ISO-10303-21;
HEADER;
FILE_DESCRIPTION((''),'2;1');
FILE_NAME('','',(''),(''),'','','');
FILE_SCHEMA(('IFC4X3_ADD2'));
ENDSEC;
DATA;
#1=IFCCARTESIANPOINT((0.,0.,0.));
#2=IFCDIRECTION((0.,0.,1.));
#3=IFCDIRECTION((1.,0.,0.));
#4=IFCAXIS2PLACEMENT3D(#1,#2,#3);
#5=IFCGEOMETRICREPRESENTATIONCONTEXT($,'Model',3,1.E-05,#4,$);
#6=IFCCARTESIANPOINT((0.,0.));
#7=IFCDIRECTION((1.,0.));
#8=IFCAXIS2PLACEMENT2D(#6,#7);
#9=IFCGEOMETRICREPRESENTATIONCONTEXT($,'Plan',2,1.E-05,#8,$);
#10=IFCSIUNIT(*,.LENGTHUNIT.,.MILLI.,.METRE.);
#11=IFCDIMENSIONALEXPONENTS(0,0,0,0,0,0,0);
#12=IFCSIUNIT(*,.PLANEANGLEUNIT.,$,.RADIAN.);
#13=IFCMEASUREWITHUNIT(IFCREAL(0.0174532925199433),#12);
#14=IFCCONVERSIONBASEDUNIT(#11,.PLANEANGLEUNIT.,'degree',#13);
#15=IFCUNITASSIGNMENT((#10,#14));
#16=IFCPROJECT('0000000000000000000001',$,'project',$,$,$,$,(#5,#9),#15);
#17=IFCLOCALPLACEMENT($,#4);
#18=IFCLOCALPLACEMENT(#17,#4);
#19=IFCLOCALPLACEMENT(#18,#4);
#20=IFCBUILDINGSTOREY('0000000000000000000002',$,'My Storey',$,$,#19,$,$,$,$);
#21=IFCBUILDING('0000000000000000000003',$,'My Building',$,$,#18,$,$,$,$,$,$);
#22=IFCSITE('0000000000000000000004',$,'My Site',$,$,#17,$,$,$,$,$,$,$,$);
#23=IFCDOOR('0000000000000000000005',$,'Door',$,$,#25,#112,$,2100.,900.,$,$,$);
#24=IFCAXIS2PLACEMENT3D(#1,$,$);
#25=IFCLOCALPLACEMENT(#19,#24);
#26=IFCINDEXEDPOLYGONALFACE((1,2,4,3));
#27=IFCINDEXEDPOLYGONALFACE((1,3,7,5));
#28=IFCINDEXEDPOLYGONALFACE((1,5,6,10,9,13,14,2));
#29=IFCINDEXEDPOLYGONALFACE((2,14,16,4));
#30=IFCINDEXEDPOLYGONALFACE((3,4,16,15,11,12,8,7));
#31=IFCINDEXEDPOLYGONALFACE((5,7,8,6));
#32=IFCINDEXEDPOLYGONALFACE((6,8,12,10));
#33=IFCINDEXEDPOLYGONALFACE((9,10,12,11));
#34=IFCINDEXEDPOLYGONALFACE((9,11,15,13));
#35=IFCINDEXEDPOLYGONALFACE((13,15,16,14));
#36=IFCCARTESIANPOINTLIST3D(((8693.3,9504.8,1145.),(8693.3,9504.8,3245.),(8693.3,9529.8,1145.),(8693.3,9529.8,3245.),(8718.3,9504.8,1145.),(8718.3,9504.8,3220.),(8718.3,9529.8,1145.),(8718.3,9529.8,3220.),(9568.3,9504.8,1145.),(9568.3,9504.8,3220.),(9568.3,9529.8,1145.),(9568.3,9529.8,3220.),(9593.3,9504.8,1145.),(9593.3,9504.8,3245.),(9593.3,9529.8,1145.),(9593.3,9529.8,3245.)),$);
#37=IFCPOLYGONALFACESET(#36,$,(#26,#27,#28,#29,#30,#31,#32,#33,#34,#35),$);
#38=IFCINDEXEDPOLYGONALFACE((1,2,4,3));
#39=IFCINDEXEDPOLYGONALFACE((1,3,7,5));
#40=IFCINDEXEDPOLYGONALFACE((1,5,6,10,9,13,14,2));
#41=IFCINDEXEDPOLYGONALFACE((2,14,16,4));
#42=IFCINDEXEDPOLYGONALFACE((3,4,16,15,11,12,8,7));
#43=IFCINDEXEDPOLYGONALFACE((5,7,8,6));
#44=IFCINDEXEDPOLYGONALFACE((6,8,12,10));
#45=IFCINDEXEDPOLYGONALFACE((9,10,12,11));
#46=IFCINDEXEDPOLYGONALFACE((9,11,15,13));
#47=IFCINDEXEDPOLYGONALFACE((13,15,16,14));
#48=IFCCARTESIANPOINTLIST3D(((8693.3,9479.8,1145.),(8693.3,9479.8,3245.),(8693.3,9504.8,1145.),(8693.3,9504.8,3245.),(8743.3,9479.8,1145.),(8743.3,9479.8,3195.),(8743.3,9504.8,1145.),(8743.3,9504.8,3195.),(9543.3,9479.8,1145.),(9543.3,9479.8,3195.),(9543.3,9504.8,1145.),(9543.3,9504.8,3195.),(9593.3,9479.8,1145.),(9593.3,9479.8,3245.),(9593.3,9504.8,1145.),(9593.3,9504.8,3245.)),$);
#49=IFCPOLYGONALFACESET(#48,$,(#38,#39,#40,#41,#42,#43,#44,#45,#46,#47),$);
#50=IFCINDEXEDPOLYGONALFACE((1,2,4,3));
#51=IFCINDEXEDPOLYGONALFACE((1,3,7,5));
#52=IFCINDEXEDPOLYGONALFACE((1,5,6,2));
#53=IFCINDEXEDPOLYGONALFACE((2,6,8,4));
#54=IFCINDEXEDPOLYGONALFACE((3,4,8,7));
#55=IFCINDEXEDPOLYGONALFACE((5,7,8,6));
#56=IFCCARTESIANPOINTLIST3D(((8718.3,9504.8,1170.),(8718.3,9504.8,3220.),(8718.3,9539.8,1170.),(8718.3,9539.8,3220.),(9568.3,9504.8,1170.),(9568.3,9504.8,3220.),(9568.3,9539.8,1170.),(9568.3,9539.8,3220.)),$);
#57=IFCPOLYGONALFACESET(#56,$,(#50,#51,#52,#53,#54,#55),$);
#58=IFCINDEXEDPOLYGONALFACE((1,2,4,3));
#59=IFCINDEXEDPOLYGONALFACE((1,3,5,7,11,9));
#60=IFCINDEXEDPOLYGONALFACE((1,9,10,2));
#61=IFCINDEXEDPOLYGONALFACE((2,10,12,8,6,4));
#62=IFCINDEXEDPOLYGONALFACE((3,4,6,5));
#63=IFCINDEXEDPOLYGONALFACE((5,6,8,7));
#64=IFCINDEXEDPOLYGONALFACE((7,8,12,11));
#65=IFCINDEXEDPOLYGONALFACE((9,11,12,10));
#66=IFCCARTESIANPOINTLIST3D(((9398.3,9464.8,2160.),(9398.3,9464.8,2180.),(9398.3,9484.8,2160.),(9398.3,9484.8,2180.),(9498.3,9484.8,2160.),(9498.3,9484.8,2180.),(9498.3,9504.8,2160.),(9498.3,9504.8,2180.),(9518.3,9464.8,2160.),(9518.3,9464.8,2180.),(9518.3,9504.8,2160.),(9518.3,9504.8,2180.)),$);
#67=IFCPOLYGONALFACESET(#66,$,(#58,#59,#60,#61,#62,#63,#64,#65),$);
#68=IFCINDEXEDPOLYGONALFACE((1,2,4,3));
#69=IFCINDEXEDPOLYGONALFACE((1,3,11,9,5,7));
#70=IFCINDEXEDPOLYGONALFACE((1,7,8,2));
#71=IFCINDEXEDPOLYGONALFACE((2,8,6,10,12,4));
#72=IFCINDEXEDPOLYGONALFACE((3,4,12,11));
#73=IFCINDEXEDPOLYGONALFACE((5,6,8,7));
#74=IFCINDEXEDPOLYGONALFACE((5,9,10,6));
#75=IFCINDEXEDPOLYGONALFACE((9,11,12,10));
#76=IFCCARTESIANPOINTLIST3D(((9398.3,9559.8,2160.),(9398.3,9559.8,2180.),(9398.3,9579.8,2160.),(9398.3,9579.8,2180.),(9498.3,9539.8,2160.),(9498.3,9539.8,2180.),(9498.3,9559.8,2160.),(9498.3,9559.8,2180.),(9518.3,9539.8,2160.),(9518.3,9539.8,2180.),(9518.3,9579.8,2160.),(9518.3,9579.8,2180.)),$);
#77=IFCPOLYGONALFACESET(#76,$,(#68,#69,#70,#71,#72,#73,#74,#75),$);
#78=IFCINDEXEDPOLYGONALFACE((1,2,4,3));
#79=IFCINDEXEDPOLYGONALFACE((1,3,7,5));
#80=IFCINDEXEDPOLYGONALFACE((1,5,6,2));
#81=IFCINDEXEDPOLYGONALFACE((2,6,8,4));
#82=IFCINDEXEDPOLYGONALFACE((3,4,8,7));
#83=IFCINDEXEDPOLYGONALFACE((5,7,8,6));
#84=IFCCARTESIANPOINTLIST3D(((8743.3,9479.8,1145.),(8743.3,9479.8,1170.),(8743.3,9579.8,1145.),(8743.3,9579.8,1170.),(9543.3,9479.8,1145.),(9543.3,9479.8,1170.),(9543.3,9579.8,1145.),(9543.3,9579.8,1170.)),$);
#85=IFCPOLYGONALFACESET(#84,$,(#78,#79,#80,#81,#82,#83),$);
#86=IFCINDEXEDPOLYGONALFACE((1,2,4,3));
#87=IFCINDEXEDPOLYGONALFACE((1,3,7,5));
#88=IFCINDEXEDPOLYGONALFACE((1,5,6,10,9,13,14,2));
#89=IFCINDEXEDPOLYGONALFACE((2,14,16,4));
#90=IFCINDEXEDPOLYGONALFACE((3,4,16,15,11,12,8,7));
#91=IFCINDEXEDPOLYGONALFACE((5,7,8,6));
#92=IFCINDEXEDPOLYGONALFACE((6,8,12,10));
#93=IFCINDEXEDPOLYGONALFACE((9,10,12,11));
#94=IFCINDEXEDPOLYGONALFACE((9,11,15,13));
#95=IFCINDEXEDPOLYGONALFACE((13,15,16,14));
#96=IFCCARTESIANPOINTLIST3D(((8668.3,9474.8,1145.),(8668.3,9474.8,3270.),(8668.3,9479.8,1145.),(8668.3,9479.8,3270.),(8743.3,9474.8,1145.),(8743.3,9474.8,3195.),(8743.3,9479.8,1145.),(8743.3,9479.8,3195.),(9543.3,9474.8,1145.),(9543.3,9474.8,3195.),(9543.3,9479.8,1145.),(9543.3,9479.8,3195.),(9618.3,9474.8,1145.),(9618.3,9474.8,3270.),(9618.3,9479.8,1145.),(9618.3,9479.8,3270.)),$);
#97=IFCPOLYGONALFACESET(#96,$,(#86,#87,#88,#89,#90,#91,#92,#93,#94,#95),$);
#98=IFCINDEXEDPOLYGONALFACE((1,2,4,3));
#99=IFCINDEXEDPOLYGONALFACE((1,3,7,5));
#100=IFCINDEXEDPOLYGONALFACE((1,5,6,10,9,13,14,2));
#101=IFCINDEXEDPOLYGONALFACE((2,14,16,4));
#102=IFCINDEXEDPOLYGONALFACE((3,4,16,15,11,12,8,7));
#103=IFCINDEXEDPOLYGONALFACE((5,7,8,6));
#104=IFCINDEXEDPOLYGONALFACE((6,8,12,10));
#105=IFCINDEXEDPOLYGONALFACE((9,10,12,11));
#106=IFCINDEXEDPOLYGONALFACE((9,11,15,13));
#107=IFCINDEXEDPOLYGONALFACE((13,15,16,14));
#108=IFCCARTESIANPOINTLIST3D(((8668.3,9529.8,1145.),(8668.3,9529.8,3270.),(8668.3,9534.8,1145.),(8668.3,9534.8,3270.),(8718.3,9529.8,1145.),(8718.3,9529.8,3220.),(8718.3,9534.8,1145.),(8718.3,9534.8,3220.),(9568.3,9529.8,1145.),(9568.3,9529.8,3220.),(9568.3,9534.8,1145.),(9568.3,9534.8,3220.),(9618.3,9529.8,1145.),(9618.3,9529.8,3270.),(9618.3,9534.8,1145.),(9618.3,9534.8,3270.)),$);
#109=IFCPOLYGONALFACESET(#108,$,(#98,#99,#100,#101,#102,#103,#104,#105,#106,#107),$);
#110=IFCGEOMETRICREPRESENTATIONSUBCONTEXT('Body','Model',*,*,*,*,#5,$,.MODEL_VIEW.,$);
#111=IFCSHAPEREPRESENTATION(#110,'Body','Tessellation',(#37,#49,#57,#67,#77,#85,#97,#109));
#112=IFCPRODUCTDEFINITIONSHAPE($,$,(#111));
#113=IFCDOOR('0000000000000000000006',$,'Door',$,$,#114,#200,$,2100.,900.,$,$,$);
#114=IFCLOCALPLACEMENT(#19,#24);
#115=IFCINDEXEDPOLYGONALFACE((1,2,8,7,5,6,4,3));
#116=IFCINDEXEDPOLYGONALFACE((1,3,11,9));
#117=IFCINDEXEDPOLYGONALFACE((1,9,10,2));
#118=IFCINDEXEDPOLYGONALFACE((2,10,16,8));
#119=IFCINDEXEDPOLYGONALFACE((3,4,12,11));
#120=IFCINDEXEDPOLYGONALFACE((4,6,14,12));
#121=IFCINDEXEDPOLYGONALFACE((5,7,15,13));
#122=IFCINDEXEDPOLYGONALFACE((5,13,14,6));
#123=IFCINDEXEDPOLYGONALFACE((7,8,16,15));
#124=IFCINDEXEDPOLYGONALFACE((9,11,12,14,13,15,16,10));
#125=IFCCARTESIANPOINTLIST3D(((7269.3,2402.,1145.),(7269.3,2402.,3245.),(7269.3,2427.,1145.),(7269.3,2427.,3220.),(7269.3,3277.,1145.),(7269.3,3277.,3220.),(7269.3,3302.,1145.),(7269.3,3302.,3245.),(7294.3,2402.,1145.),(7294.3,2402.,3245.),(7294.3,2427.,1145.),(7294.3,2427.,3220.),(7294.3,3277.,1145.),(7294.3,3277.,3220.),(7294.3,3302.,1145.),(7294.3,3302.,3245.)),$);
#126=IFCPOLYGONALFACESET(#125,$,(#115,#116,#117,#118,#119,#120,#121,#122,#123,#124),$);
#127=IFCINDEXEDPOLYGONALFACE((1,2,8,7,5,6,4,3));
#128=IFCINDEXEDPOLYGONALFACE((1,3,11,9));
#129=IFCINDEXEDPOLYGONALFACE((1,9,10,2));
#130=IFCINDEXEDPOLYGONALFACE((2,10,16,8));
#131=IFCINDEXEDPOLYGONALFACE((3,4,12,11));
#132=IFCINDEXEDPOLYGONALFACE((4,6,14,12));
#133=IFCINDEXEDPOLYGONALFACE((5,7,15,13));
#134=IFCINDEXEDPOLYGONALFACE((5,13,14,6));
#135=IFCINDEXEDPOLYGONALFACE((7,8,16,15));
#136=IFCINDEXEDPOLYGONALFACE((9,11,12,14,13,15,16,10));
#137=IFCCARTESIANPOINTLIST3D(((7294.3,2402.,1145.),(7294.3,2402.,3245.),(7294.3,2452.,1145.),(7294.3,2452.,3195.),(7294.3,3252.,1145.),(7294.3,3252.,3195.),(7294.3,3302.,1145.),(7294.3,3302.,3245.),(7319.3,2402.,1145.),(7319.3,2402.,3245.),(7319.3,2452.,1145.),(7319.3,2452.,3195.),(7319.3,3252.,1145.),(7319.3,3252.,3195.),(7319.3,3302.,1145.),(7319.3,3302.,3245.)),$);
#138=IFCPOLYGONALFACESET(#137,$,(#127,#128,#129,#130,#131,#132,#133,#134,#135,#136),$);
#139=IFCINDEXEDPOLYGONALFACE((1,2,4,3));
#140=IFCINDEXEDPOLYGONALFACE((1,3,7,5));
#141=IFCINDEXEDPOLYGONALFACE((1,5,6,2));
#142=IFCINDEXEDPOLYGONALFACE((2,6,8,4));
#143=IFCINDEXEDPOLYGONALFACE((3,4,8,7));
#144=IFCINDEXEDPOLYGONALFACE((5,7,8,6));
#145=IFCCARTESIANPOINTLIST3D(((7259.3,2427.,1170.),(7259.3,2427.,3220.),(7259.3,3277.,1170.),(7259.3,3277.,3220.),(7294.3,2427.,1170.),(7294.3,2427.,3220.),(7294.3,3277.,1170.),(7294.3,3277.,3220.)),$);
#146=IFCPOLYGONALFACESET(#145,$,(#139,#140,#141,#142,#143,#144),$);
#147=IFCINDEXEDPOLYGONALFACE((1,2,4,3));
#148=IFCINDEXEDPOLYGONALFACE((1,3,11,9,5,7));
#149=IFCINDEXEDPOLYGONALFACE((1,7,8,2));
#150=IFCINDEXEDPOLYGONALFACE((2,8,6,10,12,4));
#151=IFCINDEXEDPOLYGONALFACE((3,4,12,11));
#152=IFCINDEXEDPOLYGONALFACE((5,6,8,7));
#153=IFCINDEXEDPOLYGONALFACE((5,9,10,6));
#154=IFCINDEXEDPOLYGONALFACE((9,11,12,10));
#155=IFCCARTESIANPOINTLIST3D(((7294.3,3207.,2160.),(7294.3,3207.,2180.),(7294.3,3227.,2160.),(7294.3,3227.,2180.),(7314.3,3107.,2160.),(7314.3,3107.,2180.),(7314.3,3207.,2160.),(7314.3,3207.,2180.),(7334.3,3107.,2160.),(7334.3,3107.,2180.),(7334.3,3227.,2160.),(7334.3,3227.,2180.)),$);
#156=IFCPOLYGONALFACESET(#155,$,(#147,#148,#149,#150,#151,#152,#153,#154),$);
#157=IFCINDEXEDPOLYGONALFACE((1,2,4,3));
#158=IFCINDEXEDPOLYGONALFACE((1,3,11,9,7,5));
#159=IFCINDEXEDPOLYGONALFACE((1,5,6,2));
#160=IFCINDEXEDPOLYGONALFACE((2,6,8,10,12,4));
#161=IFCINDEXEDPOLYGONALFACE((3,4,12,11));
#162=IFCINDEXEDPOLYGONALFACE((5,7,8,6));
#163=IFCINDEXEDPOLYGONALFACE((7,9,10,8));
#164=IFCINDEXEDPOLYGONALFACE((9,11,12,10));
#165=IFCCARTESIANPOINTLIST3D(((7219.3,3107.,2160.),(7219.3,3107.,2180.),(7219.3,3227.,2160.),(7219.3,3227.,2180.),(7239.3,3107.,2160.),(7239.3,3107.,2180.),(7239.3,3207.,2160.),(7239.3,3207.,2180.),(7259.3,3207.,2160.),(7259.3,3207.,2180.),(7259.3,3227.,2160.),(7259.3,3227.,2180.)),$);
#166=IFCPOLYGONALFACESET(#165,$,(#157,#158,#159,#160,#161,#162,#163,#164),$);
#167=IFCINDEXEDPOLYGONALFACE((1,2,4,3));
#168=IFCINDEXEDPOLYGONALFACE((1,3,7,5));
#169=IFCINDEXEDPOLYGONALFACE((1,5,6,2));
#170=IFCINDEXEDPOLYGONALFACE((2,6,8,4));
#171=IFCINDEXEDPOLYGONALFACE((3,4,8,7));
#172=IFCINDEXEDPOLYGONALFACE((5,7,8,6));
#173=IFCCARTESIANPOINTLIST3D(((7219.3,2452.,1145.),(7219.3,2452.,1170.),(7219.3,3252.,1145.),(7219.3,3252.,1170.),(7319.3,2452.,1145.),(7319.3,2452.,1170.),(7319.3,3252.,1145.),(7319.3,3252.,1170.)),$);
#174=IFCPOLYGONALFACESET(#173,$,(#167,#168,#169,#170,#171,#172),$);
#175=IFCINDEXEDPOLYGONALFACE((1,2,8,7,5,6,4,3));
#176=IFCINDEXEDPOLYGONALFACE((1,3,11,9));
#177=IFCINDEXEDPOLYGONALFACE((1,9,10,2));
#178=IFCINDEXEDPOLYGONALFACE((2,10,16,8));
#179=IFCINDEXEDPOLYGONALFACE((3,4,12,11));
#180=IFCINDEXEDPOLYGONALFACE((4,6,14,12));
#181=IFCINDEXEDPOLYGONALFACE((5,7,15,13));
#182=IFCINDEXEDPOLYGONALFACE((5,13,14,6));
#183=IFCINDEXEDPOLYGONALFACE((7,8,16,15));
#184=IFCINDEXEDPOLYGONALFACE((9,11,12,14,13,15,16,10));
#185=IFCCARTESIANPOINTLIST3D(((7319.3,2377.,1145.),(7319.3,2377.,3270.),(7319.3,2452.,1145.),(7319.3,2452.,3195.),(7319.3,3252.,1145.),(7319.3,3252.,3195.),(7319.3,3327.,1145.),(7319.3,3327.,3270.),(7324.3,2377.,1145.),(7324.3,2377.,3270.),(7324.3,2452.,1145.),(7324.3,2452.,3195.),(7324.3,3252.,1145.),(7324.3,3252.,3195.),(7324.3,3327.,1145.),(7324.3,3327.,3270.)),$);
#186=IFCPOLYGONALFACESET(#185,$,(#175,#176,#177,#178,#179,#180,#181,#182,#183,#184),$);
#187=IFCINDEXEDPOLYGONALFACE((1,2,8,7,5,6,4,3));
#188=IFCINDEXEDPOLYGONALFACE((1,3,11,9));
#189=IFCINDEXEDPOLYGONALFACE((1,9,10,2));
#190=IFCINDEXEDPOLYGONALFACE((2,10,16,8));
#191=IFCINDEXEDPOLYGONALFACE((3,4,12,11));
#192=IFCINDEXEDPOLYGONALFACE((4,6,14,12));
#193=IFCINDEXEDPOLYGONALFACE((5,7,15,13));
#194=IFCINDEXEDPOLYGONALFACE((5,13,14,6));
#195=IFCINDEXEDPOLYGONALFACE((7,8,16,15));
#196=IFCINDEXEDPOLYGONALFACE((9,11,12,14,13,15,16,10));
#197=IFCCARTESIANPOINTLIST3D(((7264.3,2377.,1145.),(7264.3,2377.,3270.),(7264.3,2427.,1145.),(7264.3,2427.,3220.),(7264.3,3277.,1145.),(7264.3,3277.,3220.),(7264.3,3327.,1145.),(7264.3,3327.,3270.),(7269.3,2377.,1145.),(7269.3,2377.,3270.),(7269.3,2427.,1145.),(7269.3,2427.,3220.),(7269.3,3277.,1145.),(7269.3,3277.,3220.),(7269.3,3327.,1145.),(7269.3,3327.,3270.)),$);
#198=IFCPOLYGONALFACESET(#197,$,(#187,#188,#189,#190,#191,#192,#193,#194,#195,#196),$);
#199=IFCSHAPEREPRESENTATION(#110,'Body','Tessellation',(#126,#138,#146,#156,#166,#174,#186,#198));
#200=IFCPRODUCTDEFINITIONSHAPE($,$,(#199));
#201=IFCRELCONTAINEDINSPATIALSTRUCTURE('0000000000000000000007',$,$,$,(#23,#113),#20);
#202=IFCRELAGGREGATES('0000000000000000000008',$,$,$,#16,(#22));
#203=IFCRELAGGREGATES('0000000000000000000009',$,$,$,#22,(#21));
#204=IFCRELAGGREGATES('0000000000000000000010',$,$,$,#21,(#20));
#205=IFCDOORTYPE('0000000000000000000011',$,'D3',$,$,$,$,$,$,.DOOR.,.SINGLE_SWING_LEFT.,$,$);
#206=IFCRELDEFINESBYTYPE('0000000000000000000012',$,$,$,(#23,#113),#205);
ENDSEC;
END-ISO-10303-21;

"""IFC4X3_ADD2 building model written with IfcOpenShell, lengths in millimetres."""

from ifc_helpers import new_model, entity, si_unit, converted_unit, frame, origin_with_axes, origin_2d_with_axis, place, context, subcontext, project, spatial, line, indexed_curve, outline, extrude, shape, source, transform, mapped, type_object, type_shapes, element, save


model = new_model("IFC4X3_ADD2")

# Units and contexts
model_context = context("Model", 3, precision=1e-05, world=origin_with_axes())
plan_context = context("Plan", 2, precision=1e-05, world=origin_2d_with_axis())
body_context_1 = subcontext(model_context, "Body", "Model", "MODEL_VIEW")
body_context_2 = subcontext(plan_context, "Body", "Plan", "PLAN_VIEW")
ifc_project = project(units=[si_unit("LENGTHUNIT", "METRE", prefix="MILLI"), converted_unit("PLANEANGLEUNIT", "degree", entity("IfcReal", 0.0174532925199433), si_unit("PLANEANGLEUNIT", "RADIAN"), dimensions=[0, 0, 0, 0, 0, 0, 0])], contexts=[model_context, plan_context])

# Site, building, storey
site_placement = place(None, origin_with_axes())
site = spatial("IfcSite", under=ifc_project, at=site_placement, Name="My Site")
building_placement = place(site_placement, origin_with_axes())
building = spatial("IfcBuilding", under=site, at=building_placement, Name="My Building")
storey_placement = place(building_placement, origin_with_axes())
storey = spatial("IfcBuildingStorey", under=building, at=storey_placement, Name="My Storey")

# Doors
door_type = type_object("IfcDoorType", Name="D3", OperationType="SINGLE_SWING_LEFT", PredefinedType="DOOR")
shared_shape_1 = source(origin_with_axes(), body_context_1, "Body", "SweptSolid", [
    extrude(outline(indexed_curve([(0.0, 0.0), (0.0, 2100.0), (900.0, 2100.0), (900.0, 0.0), (875.0, 0.0), (875.0, 2075.0), (25.0, 2075.0), (25.0, 0.0)], segments=[line(1, 2, 3, 4, 5, 6, 7, 8, 1)])), frame((0.0, 25.0, 0.0), z_axis=(0.0, -1.0, 0.0), x_axis=(1.0, 0.0, 0.0)), (0.0, 0.0, -1.0), 25.0),
    extrude(outline(indexed_curve([(0.0, 0.0), (0.0, 2100.0), (900.0, 2100.0), (900.0, 0.0), (850.0, 0.0), (850.0, 2050.0), (50.0, 2050.0), (50.0, 0.0)], segments=[line(1, 2, 3, 4, 5, 6, 7, 8, 1)])), frame((0.0, 0.0, 0.0), z_axis=(0.0, -1.0, 0.0), x_axis=(1.0, 0.0, 0.0)), (0.0, 0.0, -1.0), 25.0),
    extrude(outline(indexed_curve([(0.0, 0.0), (850.0, 0.0), (850.0, 35.0), (0.0, 35.0)], segments=[line(1, 2, 3, 4, 1)])), frame((25.0, 25.0, 25.0), z_axis=(0.0, 0.0, 1.0), x_axis=(1.0, 0.0, 0.0)), (0.0, 0.0, 1.0), 2050.0),
    extrude(outline(indexed_curve([(0.0, 0.0), (0.0, -40.0), (-120.0, -40.0), (-120.0, -20.0), (-20.0, -20.0), (-20.0, 0.0)], segments=[line(1, 2, 3, 4, 5, 6, 1)])), frame((825.0, 25.0, 1015.0), z_axis=(0.0, 0.0, 1.0), x_axis=(1.0, 0.0, 0.0)), (0.0, 0.0, 1.0), 20.0),
    extrude(outline(indexed_curve([(0.0, 0.0), (0.0, 40.0), (-120.0, 40.0), (-120.0, 20.0), (-20.0, 20.0), (-20.0, 0.0)], segments=[line(1, 2, 3, 4, 5, 6, 1)])), frame((825.0, 60.0, 1015.0), z_axis=(0.0, 0.0, 1.0), x_axis=(1.0, 0.0, 0.0)), (0.0, 0.0, 1.0), 20.0),
    extrude(outline(indexed_curve([(0.0, 0.0), (800.0, 0.0), (800.0, 100.0), (0.0, 100.0)], segments=[line(1, 2, 3, 4, 1)])), frame((50.0, 0.0, 0.0), z_axis=(0.0, 0.0, 1.0), x_axis=(1.0, 0.0, 0.0)), (0.0, 0.0, 1.0), 25.0),
    extrude(outline(indexed_curve([(0.0, 0.0), (0.0, 2125.0), (950.0, 2125.0), (950.0, 0.0), (875.0, 0.0), (875.0, 2050.0), (75.0, 2050.0), (75.0, 0.0)], segments=[line(1, 2, 3, 4, 5, 6, 7, 8, 1)])), frame((-25.0, -5.0, 0.0), z_axis=(0.0, -1.0, 0.0), x_axis=(1.0, 0.0, 0.0)), (0.0, 0.0, -1.0), 5.0),
    extrude(outline(indexed_curve([(0.0, 0.0), (0.0, 2125.0), (950.0, 2125.0), (950.0, 0.0), (900.0, 0.0), (900.0, 2075.0), (50.0, 2075.0), (50.0, 0.0)], segments=[line(1, 2, 3, 4, 5, 6, 7, 8, 1)])), frame((-25.0, 50.0, 0.0), z_axis=(0.0, -1.0, 0.0), x_axis=(1.0, 0.0, 0.0)), (0.0, 0.0, -1.0), 5.0),
])
shared_shape_2 = source(origin_with_axes(), body_context_2, "Body", "Curve2D", [
    entity("IfcIndexedPolyCurve", entity("IfcCartesianPointList2D", [[0.0, 0.0], [0.0, 50.0], [25.0, 50.0], [25.0, 25.0], [50.0, 25.0], [50.0, 0.0]]), [entity("IfcLineIndex", [1, 2, 3, 4, 5, 6, 1])]),
    entity("IfcIndexedPolyCurve", entity("IfcCartesianPointList2D", [[900.0, 0.0], [900.0, 50.0], [875.0, 50.0], [875.0, 25.0], [850.0, 25.0], [850.0, 0.0]]), [entity("IfcLineIndex", [1, 2, 3, 4, 5, 6, 1])]),
    entity("IfcTrimmedCurve", entity("IfcEllipse", entity("IfcAxis2Placement2D", entity("IfcCartesianPoint", [60.0, 50.0]), entity("IfcDirection", [1.0, 0.0])), 815.0, 850.0), [entity("IfcCartesianPoint", [875.0, 50.0])], [entity("IfcCartesianPoint", [60.0, 900.0])], True, "CARTESIAN"),
    entity("IfcIndexedPolyCurve", entity("IfcCartesianPointList2D", [[25.0, 50.0], [60.0, 50.0], [60.0, 900.0], [25.0, 900.0]]), [entity("IfcLineIndex", [1, 2, 3, 4, 1])]),
])
type_shapes(door_type, [shared_shape_1, shared_shape_2])
for number, where, z_axis, x_axis, name in (
    (1, (8693.3, 9479.8, 1145.0), (0.0, 0.0, 1.0), (1.0, 0.0, 0.0), "Door"),
    (2, (7319.3, 2402.0, 1145.0), (0.0, 0.0, 1.0), (0.0, 1.0, 0.0), "Door"),
):
    element("IfcDoor", number, at=place(storey_placement, frame(where, z_axis=z_axis, x_axis=x_axis)), inside=storey, type_object=door_type, Name=name, OverallHeight=2100.0, OverallWidth=900.0, shapes=[
        shape(body_context_1, "Body", "MappedRepresentation", [mapped(shared_shape_1, transform((0.0, 0.0, 0.0), x_axis=(1.0, 0.0, 0.0), y_axis=(0.0, 1.0, 0.0), z_axis=(0.0, 0.0, 1.0), scale=1.0))]),
        shape(body_context_2, "Body", "MappedRepresentation", [mapped(shared_shape_2, transform((0.0, 0.0, 0.0), x_axis=(1.0, 0.0, 0.0), y_axis=(0.0, 1.0, 0.0), z_axis=(0.0, 0.0, 1.0), scale=1.0))]),
    ])

save(model, "model.ifc")
